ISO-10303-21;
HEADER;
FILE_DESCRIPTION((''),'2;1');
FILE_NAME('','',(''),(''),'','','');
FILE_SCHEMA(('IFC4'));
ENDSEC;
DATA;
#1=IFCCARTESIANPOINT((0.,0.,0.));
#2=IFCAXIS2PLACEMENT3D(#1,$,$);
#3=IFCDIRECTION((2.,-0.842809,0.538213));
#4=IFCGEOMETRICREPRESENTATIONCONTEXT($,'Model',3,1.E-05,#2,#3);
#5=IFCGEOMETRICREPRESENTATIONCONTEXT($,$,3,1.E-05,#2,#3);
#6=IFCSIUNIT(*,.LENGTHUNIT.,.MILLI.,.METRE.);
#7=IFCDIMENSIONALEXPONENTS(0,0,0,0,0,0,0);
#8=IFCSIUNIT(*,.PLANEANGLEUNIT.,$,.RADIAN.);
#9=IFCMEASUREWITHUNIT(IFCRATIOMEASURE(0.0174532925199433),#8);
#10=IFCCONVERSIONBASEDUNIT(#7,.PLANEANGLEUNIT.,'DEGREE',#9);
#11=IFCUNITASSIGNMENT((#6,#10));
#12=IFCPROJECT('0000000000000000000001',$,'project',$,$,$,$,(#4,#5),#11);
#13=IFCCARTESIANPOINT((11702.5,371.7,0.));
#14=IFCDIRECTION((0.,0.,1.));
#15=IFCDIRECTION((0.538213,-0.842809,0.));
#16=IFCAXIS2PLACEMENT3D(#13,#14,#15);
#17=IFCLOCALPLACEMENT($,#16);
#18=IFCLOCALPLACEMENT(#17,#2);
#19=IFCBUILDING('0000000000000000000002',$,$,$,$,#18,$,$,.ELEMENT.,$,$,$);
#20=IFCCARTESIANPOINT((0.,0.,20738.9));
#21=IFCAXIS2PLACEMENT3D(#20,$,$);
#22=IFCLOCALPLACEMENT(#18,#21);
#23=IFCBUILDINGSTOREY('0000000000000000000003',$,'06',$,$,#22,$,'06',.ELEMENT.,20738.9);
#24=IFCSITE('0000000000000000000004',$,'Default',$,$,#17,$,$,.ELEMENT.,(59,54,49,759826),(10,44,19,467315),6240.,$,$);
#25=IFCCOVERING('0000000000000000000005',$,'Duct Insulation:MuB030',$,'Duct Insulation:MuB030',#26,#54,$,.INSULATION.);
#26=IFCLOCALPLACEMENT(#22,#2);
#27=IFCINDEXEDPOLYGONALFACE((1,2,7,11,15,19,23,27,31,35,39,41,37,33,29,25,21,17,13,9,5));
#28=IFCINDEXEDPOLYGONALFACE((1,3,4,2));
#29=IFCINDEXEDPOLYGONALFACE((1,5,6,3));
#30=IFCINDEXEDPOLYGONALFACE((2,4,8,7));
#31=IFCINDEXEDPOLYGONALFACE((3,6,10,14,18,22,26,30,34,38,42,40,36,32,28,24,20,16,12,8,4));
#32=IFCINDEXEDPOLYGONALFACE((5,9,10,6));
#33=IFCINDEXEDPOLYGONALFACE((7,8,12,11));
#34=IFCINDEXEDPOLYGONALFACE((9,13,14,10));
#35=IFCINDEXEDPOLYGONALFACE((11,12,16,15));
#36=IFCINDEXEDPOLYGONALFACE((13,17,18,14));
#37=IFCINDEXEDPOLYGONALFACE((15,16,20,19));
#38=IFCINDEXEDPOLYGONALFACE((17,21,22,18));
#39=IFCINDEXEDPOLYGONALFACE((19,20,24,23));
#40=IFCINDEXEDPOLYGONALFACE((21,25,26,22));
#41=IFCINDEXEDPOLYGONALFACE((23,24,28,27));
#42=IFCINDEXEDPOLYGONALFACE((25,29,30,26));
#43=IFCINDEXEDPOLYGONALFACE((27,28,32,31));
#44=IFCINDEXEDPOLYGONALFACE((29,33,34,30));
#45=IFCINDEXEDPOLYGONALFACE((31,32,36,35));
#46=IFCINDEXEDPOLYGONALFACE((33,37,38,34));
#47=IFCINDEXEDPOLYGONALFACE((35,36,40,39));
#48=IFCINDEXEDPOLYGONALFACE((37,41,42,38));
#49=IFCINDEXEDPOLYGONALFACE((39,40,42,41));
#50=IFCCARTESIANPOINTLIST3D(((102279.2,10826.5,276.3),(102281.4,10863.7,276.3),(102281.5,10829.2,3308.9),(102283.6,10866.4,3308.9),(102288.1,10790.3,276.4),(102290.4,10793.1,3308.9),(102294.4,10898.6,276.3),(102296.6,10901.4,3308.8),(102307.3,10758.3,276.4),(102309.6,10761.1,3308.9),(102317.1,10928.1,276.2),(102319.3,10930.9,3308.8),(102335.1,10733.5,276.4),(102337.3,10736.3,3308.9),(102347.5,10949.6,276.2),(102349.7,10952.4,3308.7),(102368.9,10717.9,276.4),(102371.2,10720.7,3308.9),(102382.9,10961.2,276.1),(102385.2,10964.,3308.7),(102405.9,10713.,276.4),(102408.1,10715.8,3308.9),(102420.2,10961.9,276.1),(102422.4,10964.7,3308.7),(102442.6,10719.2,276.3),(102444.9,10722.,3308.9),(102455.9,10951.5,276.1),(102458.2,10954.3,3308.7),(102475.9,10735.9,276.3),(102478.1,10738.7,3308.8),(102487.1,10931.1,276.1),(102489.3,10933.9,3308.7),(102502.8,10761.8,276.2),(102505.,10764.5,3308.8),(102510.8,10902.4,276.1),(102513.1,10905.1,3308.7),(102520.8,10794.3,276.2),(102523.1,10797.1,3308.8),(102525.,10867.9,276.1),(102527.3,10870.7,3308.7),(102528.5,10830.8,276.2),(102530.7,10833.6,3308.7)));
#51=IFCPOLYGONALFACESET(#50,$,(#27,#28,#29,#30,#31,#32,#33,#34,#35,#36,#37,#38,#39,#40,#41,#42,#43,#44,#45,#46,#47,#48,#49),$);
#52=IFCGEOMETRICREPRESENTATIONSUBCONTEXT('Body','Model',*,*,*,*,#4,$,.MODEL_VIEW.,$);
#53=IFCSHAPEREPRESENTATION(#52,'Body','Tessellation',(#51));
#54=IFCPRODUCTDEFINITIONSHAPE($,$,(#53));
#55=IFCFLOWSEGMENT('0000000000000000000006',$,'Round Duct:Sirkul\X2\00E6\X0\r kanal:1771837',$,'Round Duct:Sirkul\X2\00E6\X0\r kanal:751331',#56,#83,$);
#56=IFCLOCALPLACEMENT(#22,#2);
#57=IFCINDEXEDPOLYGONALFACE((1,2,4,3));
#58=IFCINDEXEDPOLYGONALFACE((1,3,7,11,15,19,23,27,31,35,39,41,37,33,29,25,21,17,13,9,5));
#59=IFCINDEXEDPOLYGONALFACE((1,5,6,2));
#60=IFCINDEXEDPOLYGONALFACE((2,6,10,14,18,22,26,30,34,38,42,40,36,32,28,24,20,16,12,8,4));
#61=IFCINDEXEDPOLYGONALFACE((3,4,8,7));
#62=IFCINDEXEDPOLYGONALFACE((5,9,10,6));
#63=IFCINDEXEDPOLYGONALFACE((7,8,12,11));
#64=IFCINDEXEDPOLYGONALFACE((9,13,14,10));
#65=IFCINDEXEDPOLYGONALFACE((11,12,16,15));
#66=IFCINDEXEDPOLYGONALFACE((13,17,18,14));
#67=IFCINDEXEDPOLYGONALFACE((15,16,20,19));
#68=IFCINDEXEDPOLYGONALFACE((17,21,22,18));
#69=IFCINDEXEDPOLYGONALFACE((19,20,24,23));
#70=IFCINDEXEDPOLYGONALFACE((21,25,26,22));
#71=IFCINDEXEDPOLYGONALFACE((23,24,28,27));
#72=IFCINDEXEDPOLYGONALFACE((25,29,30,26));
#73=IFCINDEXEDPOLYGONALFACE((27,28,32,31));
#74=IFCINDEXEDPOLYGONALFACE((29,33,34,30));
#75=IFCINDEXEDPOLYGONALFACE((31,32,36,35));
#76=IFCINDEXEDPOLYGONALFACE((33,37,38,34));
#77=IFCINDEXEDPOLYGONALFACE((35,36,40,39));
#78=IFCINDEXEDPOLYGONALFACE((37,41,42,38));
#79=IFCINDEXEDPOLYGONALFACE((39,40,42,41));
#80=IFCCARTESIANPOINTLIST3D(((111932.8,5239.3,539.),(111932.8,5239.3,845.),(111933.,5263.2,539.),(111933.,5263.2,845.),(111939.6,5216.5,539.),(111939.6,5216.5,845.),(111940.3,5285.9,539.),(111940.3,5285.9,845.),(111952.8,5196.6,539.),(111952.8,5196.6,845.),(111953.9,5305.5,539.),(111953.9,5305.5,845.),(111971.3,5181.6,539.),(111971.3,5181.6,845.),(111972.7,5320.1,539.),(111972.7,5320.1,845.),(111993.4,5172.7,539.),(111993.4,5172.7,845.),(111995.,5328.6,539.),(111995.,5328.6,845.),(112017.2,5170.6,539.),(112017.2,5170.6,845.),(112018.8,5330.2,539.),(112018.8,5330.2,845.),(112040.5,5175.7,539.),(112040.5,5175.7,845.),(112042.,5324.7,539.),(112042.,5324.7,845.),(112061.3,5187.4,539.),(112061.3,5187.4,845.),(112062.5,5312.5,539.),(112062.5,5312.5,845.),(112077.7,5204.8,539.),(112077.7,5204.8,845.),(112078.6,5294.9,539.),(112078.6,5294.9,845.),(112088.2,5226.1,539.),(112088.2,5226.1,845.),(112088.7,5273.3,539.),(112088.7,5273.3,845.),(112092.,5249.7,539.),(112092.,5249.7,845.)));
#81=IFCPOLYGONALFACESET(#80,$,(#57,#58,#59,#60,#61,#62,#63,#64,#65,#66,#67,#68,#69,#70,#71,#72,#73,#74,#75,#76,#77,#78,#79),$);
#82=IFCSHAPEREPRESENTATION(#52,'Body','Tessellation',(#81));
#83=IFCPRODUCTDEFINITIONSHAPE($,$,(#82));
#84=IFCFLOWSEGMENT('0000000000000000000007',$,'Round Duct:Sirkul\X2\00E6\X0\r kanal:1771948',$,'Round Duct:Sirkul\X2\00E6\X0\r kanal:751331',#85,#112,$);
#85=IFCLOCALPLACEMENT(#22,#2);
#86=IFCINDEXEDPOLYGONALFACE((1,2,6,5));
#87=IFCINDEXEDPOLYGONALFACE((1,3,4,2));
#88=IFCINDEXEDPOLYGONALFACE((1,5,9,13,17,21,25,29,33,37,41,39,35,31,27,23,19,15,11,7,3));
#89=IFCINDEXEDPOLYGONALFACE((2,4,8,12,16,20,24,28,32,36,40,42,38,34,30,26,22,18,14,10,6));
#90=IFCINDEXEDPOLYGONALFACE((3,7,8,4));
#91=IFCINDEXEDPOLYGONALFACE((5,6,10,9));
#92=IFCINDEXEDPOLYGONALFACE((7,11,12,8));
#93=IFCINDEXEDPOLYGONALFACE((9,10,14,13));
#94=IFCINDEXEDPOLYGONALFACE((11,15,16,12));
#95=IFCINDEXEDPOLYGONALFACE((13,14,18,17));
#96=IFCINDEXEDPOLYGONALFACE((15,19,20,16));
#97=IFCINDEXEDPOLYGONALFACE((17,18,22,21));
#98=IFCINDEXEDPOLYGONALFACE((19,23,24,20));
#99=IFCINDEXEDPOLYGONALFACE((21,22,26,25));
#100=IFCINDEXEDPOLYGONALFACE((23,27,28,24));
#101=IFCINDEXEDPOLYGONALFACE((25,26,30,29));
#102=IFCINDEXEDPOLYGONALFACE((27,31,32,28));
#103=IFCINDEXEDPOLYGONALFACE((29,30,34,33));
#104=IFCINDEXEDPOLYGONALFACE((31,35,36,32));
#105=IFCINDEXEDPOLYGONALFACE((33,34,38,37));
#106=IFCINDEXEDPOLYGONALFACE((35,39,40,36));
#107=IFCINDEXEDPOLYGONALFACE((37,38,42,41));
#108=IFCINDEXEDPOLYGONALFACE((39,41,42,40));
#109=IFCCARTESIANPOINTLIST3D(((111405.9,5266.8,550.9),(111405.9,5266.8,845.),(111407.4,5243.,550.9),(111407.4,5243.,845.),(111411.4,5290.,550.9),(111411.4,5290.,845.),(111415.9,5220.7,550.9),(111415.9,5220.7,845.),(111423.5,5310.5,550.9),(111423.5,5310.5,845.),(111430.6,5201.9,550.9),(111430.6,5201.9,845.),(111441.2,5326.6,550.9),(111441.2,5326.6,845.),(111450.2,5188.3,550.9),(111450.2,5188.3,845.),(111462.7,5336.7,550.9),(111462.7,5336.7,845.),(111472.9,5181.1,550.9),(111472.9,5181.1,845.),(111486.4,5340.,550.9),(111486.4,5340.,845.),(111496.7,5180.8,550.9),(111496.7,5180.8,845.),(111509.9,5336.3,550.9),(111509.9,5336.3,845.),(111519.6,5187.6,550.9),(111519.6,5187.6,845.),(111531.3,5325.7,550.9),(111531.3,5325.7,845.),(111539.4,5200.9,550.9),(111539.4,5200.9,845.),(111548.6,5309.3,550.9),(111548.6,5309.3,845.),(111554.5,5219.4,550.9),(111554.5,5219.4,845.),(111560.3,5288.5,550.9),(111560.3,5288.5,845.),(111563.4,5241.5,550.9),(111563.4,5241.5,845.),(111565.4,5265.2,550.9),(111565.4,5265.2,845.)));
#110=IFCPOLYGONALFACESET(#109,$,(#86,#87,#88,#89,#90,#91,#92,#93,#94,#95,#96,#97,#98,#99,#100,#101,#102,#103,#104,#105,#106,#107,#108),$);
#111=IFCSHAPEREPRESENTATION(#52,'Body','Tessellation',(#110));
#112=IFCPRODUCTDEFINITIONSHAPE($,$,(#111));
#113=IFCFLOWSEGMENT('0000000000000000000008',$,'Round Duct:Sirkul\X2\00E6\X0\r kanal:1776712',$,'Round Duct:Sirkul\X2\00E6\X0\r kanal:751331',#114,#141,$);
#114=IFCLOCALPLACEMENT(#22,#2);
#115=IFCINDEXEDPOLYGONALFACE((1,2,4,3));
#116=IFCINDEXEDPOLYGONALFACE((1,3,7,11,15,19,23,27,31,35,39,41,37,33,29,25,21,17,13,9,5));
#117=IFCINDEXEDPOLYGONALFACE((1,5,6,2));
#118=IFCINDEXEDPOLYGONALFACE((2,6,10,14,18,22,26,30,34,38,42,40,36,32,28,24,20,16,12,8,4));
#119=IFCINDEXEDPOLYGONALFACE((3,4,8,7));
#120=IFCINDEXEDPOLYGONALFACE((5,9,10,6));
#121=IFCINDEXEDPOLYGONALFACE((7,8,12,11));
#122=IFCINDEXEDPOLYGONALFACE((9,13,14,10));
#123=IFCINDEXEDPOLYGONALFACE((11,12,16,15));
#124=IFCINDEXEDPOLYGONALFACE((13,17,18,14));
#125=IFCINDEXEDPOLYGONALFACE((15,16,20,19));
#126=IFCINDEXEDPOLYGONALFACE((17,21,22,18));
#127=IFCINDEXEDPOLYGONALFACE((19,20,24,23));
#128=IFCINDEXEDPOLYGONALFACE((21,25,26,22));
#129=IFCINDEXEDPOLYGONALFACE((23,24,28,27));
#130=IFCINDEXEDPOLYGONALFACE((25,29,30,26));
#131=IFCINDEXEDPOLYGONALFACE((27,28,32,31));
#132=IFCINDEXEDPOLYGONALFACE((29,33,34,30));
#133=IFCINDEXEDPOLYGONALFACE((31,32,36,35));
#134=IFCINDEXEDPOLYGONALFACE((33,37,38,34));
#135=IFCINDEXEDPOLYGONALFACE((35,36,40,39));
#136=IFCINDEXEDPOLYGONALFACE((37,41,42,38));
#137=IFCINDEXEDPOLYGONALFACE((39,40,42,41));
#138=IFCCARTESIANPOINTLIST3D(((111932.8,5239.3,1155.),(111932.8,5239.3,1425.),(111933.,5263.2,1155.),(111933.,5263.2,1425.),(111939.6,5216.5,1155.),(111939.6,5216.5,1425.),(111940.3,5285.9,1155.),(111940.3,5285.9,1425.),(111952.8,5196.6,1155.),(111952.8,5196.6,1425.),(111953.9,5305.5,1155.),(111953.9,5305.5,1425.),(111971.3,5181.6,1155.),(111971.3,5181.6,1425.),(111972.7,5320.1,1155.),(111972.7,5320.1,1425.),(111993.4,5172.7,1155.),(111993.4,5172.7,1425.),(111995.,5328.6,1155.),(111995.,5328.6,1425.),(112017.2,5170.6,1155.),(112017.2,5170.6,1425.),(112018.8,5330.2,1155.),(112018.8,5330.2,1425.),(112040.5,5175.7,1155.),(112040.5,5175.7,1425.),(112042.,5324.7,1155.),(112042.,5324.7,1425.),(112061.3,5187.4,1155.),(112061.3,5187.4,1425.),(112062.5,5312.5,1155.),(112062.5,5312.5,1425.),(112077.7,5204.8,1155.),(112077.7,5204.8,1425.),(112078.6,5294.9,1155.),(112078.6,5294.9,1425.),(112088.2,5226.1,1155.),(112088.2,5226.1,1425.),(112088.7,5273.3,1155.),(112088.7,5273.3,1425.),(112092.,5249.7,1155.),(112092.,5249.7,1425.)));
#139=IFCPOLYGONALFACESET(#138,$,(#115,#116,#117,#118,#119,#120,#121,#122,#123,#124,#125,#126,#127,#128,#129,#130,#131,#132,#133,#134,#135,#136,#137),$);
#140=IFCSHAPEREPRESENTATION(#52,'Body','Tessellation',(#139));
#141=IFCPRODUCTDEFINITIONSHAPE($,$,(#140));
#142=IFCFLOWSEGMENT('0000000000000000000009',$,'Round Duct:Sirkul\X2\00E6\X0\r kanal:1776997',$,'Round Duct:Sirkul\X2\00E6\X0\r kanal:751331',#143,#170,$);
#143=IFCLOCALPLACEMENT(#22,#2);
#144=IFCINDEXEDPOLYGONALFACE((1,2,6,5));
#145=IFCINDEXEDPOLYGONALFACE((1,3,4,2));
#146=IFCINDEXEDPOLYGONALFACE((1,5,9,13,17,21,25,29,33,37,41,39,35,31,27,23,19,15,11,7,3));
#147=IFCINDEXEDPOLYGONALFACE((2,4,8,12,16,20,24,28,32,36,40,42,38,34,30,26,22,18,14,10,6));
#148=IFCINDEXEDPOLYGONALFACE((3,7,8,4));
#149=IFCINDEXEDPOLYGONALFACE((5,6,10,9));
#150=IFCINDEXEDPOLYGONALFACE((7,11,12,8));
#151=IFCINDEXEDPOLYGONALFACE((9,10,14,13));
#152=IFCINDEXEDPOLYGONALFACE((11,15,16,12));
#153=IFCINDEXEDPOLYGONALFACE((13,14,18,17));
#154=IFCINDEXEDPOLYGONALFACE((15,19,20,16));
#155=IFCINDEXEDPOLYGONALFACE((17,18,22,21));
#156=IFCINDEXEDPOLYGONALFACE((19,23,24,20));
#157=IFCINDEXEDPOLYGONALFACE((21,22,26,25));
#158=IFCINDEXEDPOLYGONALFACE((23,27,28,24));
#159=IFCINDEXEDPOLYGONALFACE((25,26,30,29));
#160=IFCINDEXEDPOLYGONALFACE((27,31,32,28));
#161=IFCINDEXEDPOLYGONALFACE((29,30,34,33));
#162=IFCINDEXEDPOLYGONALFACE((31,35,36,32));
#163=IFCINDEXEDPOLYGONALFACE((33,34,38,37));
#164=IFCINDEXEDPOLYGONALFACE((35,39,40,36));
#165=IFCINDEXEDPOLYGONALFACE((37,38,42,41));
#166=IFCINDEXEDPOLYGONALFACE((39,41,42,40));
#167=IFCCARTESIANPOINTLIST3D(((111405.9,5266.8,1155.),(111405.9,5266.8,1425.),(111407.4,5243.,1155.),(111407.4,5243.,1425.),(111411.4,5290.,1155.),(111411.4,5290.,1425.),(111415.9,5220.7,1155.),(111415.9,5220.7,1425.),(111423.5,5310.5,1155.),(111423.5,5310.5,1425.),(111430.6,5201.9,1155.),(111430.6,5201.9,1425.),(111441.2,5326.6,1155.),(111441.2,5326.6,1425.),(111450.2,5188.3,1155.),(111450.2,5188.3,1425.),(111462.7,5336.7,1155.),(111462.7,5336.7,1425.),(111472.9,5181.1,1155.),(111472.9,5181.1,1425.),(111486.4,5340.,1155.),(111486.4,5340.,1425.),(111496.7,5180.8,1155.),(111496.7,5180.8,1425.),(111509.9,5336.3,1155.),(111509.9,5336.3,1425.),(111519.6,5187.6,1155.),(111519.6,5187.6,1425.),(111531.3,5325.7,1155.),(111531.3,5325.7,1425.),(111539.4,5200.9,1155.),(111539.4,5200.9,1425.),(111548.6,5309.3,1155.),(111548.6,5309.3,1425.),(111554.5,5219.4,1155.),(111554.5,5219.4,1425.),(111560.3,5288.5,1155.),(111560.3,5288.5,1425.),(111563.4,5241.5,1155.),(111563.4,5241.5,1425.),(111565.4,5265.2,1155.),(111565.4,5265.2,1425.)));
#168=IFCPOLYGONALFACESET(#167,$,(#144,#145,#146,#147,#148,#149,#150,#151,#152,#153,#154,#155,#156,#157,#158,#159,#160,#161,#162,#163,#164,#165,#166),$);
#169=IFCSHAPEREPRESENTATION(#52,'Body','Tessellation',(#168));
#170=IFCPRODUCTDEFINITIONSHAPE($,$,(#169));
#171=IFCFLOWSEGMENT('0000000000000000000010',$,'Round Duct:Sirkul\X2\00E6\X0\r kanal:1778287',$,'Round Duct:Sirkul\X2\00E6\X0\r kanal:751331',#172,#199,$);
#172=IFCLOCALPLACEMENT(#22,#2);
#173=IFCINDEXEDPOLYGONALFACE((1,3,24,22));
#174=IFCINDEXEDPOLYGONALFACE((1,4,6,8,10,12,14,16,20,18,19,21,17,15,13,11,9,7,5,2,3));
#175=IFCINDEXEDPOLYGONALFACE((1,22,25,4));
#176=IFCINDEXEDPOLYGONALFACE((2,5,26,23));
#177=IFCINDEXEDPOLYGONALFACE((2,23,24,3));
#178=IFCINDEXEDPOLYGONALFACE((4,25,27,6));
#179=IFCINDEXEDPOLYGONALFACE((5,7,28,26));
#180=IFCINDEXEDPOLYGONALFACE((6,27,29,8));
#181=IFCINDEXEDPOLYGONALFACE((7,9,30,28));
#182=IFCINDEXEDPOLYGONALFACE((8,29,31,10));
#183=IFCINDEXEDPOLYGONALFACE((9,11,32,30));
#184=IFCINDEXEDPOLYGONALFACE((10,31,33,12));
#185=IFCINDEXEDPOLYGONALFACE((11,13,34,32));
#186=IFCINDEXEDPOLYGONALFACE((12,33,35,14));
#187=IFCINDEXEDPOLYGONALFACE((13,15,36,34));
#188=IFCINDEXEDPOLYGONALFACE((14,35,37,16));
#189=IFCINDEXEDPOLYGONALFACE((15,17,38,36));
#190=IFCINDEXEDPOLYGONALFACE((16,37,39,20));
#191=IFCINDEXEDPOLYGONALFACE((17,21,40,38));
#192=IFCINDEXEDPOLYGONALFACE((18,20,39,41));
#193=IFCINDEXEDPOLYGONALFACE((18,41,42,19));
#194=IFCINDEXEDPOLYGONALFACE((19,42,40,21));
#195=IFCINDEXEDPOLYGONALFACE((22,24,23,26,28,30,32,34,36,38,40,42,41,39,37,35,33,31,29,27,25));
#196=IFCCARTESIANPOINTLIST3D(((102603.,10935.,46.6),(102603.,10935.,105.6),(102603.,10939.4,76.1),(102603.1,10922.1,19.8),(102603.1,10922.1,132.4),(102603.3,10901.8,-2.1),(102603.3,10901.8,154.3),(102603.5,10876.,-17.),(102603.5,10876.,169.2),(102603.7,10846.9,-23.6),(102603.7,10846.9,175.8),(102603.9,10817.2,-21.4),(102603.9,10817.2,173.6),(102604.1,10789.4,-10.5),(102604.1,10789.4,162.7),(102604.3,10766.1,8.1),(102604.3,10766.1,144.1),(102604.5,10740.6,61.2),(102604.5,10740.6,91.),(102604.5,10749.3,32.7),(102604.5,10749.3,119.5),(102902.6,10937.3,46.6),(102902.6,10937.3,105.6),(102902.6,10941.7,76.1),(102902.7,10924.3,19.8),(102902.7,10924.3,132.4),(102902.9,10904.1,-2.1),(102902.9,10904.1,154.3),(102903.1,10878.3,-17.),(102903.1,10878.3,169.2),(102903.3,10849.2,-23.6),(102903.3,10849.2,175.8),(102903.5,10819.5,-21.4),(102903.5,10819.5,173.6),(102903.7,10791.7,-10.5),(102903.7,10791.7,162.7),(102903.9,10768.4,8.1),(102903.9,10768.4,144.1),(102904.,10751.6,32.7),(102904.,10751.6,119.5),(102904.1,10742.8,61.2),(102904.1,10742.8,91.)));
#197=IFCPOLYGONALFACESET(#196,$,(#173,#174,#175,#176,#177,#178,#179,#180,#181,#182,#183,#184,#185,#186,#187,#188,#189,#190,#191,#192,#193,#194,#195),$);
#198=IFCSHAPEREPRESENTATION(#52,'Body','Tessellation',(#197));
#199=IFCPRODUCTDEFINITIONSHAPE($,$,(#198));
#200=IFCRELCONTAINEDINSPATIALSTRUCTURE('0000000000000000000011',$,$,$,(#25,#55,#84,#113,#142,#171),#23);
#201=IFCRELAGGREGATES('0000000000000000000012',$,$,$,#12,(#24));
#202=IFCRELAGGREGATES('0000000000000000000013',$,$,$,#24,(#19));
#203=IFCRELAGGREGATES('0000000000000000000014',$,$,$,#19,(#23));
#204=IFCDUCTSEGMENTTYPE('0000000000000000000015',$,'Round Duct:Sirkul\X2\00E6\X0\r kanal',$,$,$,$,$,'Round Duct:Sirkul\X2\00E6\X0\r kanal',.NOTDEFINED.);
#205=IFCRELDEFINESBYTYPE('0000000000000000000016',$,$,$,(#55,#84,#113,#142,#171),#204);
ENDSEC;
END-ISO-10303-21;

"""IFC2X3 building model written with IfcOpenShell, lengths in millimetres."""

from ifc_helpers import new_model, entity, si_unit, converted_unit, direction, frame, frame_2d, origin, origin_2d_with_axis, place, context, subcontext, project, spatial, circle, extrude, type_object, element, save


model = new_model("IFC2X3")

# Units and contexts
model_context = context("Model", 3, precision=1e-05, world=origin(), true_north=direction((2.0, -0.842809, 0.538213)))
context_of_model = context(None, 3, precision=1e-05, world=origin(), true_north=direction((2.0, -0.842809, 0.538213)))
body_context = subcontext(model_context, "Body", "Model", "MODEL_VIEW")
ifc_project = project(units=[si_unit("LENGTHUNIT", "METRE", prefix="MILLI"), converted_unit("PLANEANGLEUNIT", "DEGREE", entity("IfcRatioMeasure", 0.0174532925199433), si_unit("PLANEANGLEUNIT", "RADIAN"), dimensions=[0, 0, 0, 0, 0, 0, 0])], contexts=[model_context, context_of_model])

# Site, building, storey
site_placement = place(None, frame((11702.5, 371.7, 0.0), z_axis=(0.0, 0.0, 1.0), x_axis=(0.538213, -0.842809, 0.0)))
site = spatial("IfcSite", under=ifc_project, at=site_placement, Name="Default", CompositionType="ELEMENT", RefLatitude=(59, 54, 49, 759826), RefLongitude=(10, 44, 19, 467315), RefElevation=6240.0)
building_placement = place(site_placement, origin())
building = spatial("IfcBuilding", under=site, at=building_placement, CompositionType="ELEMENT")
storey_placement = place(building_placement, frame((0.0, 0.0, 20738.9)))
storey = spatial("IfcBuildingStorey", under=building, at=storey_placement, Name="06", LongName="06", CompositionType="ELEMENT", Elevation=20738.9)

# Covering
covering_1_placement = place(storey_placement, origin())
element("IfcCovering", 1, at=covering_1_placement, inside=storey, Name="Duct Insulation:MuB030", ObjectType="Duct Insulation:MuB030", PredefinedType="INSULATION", context=body_context, shape_type="SweptSolid", body=[
    extrude(circle(Radius=125.0, at=frame_2d((0.0, 0.0), x_axis=(1.0, 0.0))), frame((102403.7, 10838.0, 276.2), z_axis=(0.000742, 0.000917, 0.999999), x_axis=(0.857167, 0.515038, -0.001109)), (0.0, 0.0, 1.0), 3032.6),
])

# Flow segments
duct_segment_type = type_object("IfcDuctSegmentType", Name="Round Duct:Sirkulær kanal", ElementType="Round Duct:Sirkulær kanal", PredefinedType="NOTDEFINED")
flow_segment_1_placement = place(storey_placement, origin())
element("IfcFlowSegment", 2, at=flow_segment_1_placement, inside=storey, type_object=duct_segment_type, Name="Round Duct:Sirkulær kanal:1771837", ObjectType="Round Duct:Sirkulær kanal:751331", context=body_context, shape_type="SweptSolid", body=[
    extrude(circle(Radius=80.0, at=origin_2d_with_axis()), frame((112012.0, 5250.5, 539.0), z_axis=(0.0, 0.0, 1.0), x_axis=(0.999952, -0.00981, 0.0)), (0.0, 0.0, 1.0), 306.0),
])
flow_segment_2_placement = place(storey_placement, origin())
element("IfcFlowSegment", 3, at=flow_segment_2_placement, inside=storey, type_object=duct_segment_type, Name="Round Duct:Sirkulær kanal:1771948", ObjectType="Round Duct:Sirkulær kanal:751331", context=body_context, shape_type="SweptSolid", body=[
    extrude(circle(Radius=80.0, at=origin_2d_with_axis()), frame((111485.6, 5260.0, 550.9), z_axis=(0.0, 0.0, 1.0), x_axis=(0.00981, 0.999952, 0.0)), (0.0, 0.0, 1.0), 294.1),
])
flow_segment_3_placement = place(storey_placement, origin())
element("IfcFlowSegment", 4, at=flow_segment_3_placement, inside=storey, type_object=duct_segment_type, Name="Round Duct:Sirkulær kanal:1776712", ObjectType="Round Duct:Sirkulær kanal:751331", context=body_context, shape_type="SweptSolid", body=[
    extrude(circle(Radius=80.0, at=origin_2d_with_axis()), frame((112012.0, 5250.5, 1155.0), z_axis=(0.0, 0.0, 1.0), x_axis=(0.999952, -0.00981, 0.0)), (0.0, 0.0, 1.0), 270.0),
])
flow_segment_4_placement = place(storey_placement, origin())
element("IfcFlowSegment", 5, at=flow_segment_4_placement, inside=storey, type_object=duct_segment_type, Name="Round Duct:Sirkulær kanal:1776997", ObjectType="Round Duct:Sirkulær kanal:751331", context=body_context, shape_type="SweptSolid", body=[
    extrude(circle(Radius=80.0, at=origin_2d_with_axis()), frame((111485.6, 5260.0, 1155.0), z_axis=(0.0, 0.0, 1.0), x_axis=(0.00981, 0.999952, 0.0)), (0.0, 0.0, 1.0), 270.0),
])
flow_segment_5_placement = place(storey_placement, origin())
element("IfcFlowSegment", 6, at=flow_segment_5_placement, inside=storey, type_object=duct_segment_type, Name="Round Duct:Sirkulær kanal:1778287", ObjectType="Round Duct:Sirkulær kanal:751331", context=body_context, shape_type="SweptSolid", body=[
    extrude(circle(Radius=100.0, at=frame_2d((0.0, 0.0), x_axis=(1.0, 0.0))), frame((102603.8, 10839.4, 76.1), z_axis=(0.999971, 0.007643, 0.0), x_axis=(-0.007643, 0.999971, 0.0)), (0.0, 0.0, 1.0), 299.6),
])

save(model, "model.ifc")
